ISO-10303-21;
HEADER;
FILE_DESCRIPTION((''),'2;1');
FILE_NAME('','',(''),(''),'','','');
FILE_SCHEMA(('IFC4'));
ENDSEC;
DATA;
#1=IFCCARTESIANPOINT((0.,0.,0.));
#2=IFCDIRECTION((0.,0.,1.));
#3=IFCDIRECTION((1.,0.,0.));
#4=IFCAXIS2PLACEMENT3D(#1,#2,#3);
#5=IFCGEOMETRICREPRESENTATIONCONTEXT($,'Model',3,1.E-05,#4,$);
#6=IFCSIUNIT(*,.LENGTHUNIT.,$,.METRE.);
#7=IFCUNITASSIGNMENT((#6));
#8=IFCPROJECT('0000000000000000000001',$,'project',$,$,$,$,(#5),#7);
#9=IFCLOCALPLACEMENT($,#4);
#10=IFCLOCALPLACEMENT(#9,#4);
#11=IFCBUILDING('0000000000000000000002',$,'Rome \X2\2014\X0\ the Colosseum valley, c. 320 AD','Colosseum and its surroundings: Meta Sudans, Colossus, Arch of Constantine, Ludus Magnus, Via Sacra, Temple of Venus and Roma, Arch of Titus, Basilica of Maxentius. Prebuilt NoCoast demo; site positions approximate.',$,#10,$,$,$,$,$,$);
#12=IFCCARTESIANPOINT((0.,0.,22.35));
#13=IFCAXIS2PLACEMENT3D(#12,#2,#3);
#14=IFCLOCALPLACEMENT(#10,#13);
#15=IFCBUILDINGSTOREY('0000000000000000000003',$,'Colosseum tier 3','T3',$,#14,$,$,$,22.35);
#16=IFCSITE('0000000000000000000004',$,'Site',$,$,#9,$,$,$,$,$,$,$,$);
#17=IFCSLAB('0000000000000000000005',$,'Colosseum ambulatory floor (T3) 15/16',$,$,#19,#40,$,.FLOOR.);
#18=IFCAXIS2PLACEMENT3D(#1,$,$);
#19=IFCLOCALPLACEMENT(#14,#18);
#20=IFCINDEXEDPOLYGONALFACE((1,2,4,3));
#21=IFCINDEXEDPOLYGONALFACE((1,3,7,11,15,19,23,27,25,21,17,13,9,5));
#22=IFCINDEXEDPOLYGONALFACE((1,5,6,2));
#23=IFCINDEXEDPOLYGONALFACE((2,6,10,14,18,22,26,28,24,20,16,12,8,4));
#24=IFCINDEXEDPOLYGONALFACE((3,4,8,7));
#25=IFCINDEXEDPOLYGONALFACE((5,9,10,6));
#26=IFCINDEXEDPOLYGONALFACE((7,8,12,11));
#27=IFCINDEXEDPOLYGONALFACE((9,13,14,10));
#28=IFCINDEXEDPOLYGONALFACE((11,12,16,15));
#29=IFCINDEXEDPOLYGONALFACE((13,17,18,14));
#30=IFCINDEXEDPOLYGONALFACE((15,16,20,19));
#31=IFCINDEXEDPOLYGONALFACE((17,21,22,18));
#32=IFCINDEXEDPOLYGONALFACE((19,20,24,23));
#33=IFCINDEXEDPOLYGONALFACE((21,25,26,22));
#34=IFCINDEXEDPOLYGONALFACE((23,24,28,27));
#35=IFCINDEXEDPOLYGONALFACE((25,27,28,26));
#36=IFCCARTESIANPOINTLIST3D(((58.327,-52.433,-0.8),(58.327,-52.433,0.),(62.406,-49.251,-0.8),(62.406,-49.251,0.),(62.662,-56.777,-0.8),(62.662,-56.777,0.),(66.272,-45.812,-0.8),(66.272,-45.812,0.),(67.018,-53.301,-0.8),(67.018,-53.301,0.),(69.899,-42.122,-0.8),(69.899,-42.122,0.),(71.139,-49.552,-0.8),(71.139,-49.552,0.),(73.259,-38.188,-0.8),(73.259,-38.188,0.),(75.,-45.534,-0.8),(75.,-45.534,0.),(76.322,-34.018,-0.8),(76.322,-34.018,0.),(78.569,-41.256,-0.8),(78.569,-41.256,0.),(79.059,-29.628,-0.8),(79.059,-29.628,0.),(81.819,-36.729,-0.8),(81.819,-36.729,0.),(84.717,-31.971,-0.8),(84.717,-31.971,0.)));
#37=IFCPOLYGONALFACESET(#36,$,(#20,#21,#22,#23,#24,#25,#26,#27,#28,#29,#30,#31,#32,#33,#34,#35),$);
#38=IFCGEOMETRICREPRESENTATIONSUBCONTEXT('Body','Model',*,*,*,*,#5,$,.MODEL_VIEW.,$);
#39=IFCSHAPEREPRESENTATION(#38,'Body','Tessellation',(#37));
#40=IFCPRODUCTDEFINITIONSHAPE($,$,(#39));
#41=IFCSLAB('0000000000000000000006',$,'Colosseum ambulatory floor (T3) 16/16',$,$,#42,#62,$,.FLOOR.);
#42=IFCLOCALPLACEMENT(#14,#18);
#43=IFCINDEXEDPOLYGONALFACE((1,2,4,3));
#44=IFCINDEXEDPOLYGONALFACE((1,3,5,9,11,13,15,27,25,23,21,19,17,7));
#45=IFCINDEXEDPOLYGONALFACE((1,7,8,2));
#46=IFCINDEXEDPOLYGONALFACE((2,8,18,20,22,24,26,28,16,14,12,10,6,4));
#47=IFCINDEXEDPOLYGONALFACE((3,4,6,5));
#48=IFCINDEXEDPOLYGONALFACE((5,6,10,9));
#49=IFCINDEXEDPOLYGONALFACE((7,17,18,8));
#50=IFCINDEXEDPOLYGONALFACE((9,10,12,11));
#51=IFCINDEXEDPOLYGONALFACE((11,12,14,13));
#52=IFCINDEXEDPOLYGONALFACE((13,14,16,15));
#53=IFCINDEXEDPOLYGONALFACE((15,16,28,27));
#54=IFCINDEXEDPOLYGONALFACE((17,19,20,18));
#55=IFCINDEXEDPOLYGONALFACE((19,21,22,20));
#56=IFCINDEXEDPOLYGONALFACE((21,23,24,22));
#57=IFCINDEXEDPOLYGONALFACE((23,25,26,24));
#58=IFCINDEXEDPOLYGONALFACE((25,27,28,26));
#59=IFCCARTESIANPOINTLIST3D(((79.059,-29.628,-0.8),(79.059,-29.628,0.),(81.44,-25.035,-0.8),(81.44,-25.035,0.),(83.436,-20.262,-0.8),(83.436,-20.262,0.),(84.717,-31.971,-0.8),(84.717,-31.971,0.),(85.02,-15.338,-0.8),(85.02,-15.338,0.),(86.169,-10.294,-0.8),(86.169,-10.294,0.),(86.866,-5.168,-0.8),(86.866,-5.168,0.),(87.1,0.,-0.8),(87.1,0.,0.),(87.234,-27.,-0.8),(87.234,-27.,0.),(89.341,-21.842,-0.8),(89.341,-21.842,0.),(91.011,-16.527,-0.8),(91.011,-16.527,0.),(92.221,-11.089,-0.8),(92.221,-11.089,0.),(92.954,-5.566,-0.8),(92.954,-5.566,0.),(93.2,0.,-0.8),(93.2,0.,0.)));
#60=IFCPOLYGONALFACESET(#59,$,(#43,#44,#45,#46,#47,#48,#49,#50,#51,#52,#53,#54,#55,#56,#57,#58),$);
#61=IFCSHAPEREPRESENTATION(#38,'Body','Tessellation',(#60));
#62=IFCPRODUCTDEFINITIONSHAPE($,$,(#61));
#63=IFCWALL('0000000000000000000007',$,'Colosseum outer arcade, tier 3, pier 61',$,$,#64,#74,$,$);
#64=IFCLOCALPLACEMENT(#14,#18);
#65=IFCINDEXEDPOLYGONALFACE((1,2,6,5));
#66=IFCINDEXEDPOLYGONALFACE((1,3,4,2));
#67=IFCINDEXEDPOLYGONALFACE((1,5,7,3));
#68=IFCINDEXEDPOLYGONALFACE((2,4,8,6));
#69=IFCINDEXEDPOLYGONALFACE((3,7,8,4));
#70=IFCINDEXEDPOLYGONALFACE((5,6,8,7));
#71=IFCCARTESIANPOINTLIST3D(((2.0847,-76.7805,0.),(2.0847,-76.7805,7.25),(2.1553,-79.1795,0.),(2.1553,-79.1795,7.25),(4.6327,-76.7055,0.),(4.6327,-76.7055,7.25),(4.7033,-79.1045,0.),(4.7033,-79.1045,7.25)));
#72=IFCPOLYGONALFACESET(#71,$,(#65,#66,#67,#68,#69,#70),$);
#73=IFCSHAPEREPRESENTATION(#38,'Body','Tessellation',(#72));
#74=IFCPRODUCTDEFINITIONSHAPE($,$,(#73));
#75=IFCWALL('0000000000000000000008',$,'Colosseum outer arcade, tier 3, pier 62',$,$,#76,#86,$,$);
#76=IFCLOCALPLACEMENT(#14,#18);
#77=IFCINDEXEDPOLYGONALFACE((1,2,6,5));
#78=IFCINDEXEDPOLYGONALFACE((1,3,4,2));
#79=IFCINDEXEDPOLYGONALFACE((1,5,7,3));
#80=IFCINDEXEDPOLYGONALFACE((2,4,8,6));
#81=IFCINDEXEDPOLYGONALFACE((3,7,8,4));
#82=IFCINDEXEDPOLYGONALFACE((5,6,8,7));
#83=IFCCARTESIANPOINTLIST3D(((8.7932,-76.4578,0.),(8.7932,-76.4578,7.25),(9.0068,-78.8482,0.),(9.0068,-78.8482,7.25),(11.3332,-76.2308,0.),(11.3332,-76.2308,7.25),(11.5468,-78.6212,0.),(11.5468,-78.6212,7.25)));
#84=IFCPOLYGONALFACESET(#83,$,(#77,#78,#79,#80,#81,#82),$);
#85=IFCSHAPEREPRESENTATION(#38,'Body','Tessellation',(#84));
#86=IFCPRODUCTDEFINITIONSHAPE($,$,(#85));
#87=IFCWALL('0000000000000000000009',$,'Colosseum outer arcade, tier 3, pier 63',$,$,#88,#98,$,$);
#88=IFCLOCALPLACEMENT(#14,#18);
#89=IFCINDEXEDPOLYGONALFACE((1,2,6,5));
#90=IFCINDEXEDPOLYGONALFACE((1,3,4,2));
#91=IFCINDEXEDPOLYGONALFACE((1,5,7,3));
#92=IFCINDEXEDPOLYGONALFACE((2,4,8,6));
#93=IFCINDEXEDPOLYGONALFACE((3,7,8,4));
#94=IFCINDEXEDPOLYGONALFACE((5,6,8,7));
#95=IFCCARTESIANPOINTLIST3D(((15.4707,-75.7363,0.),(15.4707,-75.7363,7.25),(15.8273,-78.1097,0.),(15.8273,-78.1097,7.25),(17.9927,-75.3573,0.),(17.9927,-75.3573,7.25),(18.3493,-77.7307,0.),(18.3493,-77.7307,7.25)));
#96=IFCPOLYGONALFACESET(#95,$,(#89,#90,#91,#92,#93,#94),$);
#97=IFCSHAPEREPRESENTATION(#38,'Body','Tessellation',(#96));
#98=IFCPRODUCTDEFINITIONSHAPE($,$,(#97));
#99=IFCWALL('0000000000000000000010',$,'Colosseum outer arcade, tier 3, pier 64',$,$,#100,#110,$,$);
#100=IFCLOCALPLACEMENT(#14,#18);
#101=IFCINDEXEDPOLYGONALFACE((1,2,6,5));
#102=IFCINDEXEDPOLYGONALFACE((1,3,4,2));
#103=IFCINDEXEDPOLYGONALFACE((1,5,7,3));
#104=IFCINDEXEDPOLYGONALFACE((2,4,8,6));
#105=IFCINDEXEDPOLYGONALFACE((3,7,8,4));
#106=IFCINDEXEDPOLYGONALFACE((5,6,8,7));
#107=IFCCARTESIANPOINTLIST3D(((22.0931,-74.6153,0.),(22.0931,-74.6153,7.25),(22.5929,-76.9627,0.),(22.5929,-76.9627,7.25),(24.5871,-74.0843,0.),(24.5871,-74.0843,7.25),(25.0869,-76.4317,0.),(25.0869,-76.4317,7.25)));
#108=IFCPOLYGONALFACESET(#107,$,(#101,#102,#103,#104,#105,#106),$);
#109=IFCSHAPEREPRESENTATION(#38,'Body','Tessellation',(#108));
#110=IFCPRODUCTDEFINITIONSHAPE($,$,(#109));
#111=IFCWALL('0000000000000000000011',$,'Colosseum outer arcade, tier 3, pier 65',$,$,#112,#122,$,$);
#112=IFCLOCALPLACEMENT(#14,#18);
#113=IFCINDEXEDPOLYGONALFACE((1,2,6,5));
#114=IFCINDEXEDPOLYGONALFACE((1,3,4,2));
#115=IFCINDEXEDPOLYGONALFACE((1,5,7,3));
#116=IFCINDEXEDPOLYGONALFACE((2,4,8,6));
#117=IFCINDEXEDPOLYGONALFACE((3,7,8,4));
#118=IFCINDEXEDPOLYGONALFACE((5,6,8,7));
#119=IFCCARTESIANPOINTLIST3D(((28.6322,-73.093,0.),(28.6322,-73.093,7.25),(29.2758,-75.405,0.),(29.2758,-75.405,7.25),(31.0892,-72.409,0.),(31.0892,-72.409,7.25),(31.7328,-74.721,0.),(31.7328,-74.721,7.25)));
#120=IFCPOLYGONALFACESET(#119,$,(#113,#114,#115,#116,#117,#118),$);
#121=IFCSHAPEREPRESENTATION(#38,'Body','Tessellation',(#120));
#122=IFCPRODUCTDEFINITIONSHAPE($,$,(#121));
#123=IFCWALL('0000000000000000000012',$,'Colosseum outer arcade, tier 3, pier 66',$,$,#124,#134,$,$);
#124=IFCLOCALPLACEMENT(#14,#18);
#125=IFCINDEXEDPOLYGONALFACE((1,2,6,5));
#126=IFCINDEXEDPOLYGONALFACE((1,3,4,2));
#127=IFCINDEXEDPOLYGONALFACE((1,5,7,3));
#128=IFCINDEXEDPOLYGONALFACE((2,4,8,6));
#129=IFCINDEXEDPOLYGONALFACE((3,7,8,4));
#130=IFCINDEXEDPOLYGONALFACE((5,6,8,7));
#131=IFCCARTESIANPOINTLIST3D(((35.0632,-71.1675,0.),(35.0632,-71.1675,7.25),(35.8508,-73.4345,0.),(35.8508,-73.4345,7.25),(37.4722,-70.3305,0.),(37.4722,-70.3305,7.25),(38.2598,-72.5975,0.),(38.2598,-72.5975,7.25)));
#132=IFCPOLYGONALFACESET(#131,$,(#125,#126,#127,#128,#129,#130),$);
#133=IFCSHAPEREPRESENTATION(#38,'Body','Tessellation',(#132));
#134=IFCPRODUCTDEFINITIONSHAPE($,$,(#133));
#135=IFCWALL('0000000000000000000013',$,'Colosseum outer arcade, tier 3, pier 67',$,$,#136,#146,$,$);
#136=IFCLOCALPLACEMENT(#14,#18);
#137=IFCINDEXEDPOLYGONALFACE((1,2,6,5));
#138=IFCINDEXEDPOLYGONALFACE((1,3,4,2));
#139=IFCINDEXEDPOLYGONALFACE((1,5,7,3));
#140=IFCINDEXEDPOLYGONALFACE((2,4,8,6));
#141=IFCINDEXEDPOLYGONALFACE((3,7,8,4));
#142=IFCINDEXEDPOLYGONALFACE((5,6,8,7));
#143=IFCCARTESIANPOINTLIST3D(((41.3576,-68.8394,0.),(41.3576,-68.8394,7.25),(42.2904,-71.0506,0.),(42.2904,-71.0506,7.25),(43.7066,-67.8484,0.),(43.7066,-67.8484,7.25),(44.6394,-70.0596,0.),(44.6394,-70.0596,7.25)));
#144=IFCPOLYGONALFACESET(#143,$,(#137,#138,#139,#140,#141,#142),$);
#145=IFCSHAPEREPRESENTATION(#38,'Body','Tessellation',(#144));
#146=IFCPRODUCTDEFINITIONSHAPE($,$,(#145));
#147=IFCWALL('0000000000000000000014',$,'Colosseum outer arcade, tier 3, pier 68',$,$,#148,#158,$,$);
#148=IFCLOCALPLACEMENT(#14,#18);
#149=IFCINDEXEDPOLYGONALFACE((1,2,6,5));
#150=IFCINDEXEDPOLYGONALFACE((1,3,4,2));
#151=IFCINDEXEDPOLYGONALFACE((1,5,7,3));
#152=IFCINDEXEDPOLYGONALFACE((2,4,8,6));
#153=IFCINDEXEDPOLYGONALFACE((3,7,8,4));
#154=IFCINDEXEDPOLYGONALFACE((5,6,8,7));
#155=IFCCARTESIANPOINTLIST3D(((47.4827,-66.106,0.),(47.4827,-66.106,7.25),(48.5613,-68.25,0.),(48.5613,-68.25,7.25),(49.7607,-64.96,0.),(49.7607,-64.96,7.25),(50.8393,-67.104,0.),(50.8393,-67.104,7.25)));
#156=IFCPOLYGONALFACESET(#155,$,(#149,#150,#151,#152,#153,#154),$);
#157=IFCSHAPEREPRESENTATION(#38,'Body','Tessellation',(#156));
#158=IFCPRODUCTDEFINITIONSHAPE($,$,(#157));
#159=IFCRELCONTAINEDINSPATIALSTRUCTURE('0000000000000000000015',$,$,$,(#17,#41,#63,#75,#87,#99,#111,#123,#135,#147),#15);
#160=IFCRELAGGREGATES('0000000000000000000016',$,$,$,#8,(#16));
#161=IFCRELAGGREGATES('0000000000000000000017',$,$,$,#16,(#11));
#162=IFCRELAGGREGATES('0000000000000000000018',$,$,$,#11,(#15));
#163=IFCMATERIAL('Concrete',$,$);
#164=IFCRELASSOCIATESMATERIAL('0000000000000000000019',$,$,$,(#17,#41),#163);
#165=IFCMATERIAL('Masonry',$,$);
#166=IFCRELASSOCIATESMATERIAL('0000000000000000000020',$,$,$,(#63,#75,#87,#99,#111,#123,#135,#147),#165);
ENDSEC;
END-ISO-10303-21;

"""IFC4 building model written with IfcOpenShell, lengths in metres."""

from ifc_helpers import new_model, si_unit, frame, origin_with_axes, place, context, subcontext, project, spatial, indexed_curve, outline, extrude, material, element, save


model = new_model("IFC4")

# Units and contexts
model_context = context("Model", 3, precision=1e-05, world=origin_with_axes())
body_context = subcontext(model_context, "Body", "Model", "MODEL_VIEW")
ifc_project = project(units=[si_unit("LENGTHUNIT", "METRE")], contexts=[model_context])

# Site, building, storey
site_placement = place(None, origin_with_axes())
site = spatial("IfcSite", under=ifc_project, at=site_placement, Name="Site")
building_placement = place(site_placement, origin_with_axes())
building = spatial("IfcBuilding", under=site, at=building_placement, Name="Rome — the Colosseum valley, c. 320 AD", Description="Colosseum and its surroundings: Meta Sudans, Colossus, Arch of Constantine, Ludus Magnus, Via Sacra, Temple of Venus and Roma, Arch of Titus, Basilica of Maxentius. Prebuilt NoCoast demo; site positions approximate.")
storey_placement = place(building_placement, frame((0.0, 0.0, 22.35), z_axis=(0.0, 0.0, 1.0), x_axis=(1.0, 0.0, 0.0)))
storey = spatial("IfcBuildingStorey", under=building, at=storey_placement, Name="Colosseum tier 3", Description="T3", Elevation=22.35)

# Slabs
ifc_material_1 = material(Name="Concrete")
slab_1_placement = place(storey_placement, frame((0.0, 0.0, -0.8), z_axis=(0.0, 0.0, 1.0), x_axis=(1.0, 0.0, 0.0)))
element("IfcSlab", 1, at=slab_1_placement, inside=storey, material=ifc_material_1, Name="Colosseum ambulatory floor (T3) 15/16", PredefinedType="FLOOR", context=body_context, shape_type="SweptSolid", body=[
    extrude(outline(indexed_curve([(58.327, -52.433), (62.406, -49.251), (66.272, -45.812), (69.899, -42.122), (73.259, -38.188), (76.322, -34.018), (79.059, -29.628), (84.717, -31.971), (81.819, -36.729), (78.569, -41.256), (75.0, -45.534), (71.139, -49.552), (67.018, -53.301), (62.662, -56.777)])), None, (0.0, 0.0, 1.0), 0.8),
])
slab_2_placement = place(storey_placement, frame((0.0, 0.0, -0.8), z_axis=(0.0, 0.0, 1.0), x_axis=(1.0, 0.0, 0.0)))
element("IfcSlab", 2, at=slab_2_placement, inside=storey, material=ifc_material_1, Name="Colosseum ambulatory floor (T3) 16/16", PredefinedType="FLOOR", context=body_context, shape_type="SweptSolid", body=[
    extrude(outline(indexed_curve([(79.059, -29.628), (81.44, -25.035), (83.436, -20.262), (85.02, -15.338), (86.169, -10.294), (86.866, -5.168), (87.1, 0.0), (93.2, 0.0), (92.954, -5.566), (92.221, -11.089), (91.011, -16.527), (89.341, -21.842), (87.234, -27.0), (84.717, -31.971)])), None, (0.0, 0.0, 1.0), 0.8),
])

# Walls
ifc_material_2 = material(Name="Masonry")
wall_1_placement = place(storey_placement, frame((2.12, -77.98, 0.0), z_axis=(0.0, 0.0, 1.0), x_axis=(0.999567, 0.029422, 0.0)))
element("IfcWall", 3, at=wall_1_placement, inside=storey, material=ifc_material_2, Name="Colosseum outer arcade, tier 3, pier 61", context=body_context, shape_type="SweptSolid", body=[
    extrude(outline(indexed_curve([(0.0, 0.0), (0.0, 2.4), (2.5491, 2.4), (2.5491, 0.0), (0.0, 0.0)], self_intersect=False)), frame((0.0, -1.2, 0.0), z_axis=(0.0, 0.0, 1.0), x_axis=(1.0, 0.0, 0.0)), (0.0, 0.0, 1.0), 7.25),
])
wall_2_placement = place(storey_placement, frame((8.9, -77.653, 0.0), z_axis=(0.0, 0.0, 1.0), x_axis=(0.99603, 0.089015, 0.0)))
element("IfcWall", 4, at=wall_2_placement, inside=storey, material=ifc_material_2, Name="Colosseum outer arcade, tier 3, pier 62", context=body_context, shape_type="SweptSolid", body=[
    extrude(outline(indexed_curve([(0.0, 0.0), (0.0, 2.4), (2.5501, 2.4), (2.5501, 0.0), (0.0, 0.0)], self_intersect=False)), frame((0.0, -1.2, 0.0), z_axis=(0.0, 0.0, 1.0), x_axis=(1.0, 0.0, 0.0)), (0.0, 0.0, 1.0), 7.25),
])
wall_3_placement = place(storey_placement, frame((15.649, -76.923, 0.0), z_axis=(0.0, 0.0, 1.0), x_axis=(0.988896, 0.148609, 0.0)))
element("IfcWall", 5, at=wall_3_placement, inside=storey, material=ifc_material_2, Name="Colosseum outer arcade, tier 3, pier 63", context=body_context, shape_type="SweptSolid", body=[
    extrude(outline(indexed_curve([(0.0, 0.0), (0.0, 2.4), (2.5503, 2.4), (2.5503, 0.0), (0.0, 0.0)], self_intersect=False)), frame((0.0, -1.2, 0.0), z_axis=(0.0, 0.0, 1.0), x_axis=(1.0, 0.0, 0.0)), (0.0, 0.0, 1.0), 7.25),
])
wall_4_placement = place(storey_placement, frame((22.343, -75.789, 0.0), z_axis=(0.0, 0.0, 1.0), x_axis=(0.978077, 0.208243, 0.0)))
element("IfcWall", 6, at=wall_4_placement, inside=storey, material=ifc_material_2, Name="Colosseum outer arcade, tier 3, pier 64", context=body_context, shape_type="SweptSolid", body=[
    extrude(outline(indexed_curve([(0.0, 0.0), (0.0, 2.4), (2.5499, 2.4), (2.5499, 0.0), (0.0, 0.0)], self_intersect=False)), frame((0.0, -1.2, 0.0), z_axis=(0.0, 0.0, 1.0), x_axis=(1.0, 0.0, 0.0)), (0.0, 0.0, 1.0), 7.25),
])
wall_5_placement = place(storey_placement, frame((28.954, -74.249, 0.0), z_axis=(0.0, 0.0, 1.0), x_axis=(0.963366, 0.26819, 0.0)))
element("IfcWall", 7, at=wall_5_placement, inside=storey, material=ifc_material_2, Name="Colosseum outer arcade, tier 3, pier 65", context=body_context, shape_type="SweptSolid", body=[
    extrude(outline(indexed_curve([(0.0, 0.0), (0.0, 2.4), (2.5504, 2.4), (2.5504, 0.0), (0.0, 0.0)], self_intersect=False)), frame((0.0, -1.2, 0.0), z_axis=(0.0, 0.0, 1.0), x_axis=(1.0, 0.0, 0.0)), (0.0, 0.0, 1.0), 7.25),
])
wall_6_placement = place(storey_placement, frame((35.457, -72.301, 0.0), z_axis=(0.0, 0.0, 1.0), x_axis=(0.944608, 0.328201, 0.0)))
element("IfcWall", 8, at=wall_6_placement, inside=storey, material=ifc_material_2, Name="Colosseum outer arcade, tier 3, pier 66", context=body_context, shape_type="SweptSolid", body=[
    extrude(outline(indexed_curve([(0.0, 0.0), (0.0, 2.4), (2.5503, 2.4), (2.5503, 0.0), (0.0, 0.0)], self_intersect=False)), frame((0.0, -1.2, 0.0), z_axis=(0.0, 0.0, 1.0), x_axis=(1.0, 0.0, 0.0)), (0.0, 0.0, 1.0), 7.25),
])
wall_7_placement = place(storey_placement, frame((41.824, -69.945, 0.0), z_axis=(0.0, 0.0, 1.0), x_axis=(0.921362, 0.388706, 0.0)))
element("IfcWall", 9, at=wall_7_placement, inside=storey, material=ifc_material_2, Name="Colosseum outer arcade, tier 3, pier 67", context=body_context, shape_type="SweptSolid", body=[
    extrude(outline(indexed_curve([(0.0, 0.0), (0.0, 2.4), (2.5495, 2.4), (2.5495, 0.0), (0.0, 0.0)], self_intersect=False)), frame((0.0, -1.2, 0.0), z_axis=(0.0, 0.0, 1.0), x_axis=(1.0, 0.0, 0.0)), (0.0, 0.0, 1.0), 7.25),
])
wall_8_placement = place(storey_placement, frame((48.022, -67.178, 0.0), z_axis=(0.0, 0.0, 1.0), x_axis=(0.893326, 0.449408, 0.0)))
element("IfcWall", 10, at=wall_8_placement, inside=storey, material=ifc_material_2, Name="Colosseum outer arcade, tier 3, pier 68", context=body_context, shape_type="SweptSolid", body=[
    extrude(outline(indexed_curve([(0.0, 0.0), (0.0, 2.4), (2.55, 2.4), (2.55, 0.0), (0.0, 0.0)], self_intersect=False)), frame((0.0, -1.2, 0.0), z_axis=(0.0, 0.0, 1.0), x_axis=(1.0, 0.0, 0.0)), (0.0, 0.0, 1.0), 7.25),
])

save(model, "model.ifc")
